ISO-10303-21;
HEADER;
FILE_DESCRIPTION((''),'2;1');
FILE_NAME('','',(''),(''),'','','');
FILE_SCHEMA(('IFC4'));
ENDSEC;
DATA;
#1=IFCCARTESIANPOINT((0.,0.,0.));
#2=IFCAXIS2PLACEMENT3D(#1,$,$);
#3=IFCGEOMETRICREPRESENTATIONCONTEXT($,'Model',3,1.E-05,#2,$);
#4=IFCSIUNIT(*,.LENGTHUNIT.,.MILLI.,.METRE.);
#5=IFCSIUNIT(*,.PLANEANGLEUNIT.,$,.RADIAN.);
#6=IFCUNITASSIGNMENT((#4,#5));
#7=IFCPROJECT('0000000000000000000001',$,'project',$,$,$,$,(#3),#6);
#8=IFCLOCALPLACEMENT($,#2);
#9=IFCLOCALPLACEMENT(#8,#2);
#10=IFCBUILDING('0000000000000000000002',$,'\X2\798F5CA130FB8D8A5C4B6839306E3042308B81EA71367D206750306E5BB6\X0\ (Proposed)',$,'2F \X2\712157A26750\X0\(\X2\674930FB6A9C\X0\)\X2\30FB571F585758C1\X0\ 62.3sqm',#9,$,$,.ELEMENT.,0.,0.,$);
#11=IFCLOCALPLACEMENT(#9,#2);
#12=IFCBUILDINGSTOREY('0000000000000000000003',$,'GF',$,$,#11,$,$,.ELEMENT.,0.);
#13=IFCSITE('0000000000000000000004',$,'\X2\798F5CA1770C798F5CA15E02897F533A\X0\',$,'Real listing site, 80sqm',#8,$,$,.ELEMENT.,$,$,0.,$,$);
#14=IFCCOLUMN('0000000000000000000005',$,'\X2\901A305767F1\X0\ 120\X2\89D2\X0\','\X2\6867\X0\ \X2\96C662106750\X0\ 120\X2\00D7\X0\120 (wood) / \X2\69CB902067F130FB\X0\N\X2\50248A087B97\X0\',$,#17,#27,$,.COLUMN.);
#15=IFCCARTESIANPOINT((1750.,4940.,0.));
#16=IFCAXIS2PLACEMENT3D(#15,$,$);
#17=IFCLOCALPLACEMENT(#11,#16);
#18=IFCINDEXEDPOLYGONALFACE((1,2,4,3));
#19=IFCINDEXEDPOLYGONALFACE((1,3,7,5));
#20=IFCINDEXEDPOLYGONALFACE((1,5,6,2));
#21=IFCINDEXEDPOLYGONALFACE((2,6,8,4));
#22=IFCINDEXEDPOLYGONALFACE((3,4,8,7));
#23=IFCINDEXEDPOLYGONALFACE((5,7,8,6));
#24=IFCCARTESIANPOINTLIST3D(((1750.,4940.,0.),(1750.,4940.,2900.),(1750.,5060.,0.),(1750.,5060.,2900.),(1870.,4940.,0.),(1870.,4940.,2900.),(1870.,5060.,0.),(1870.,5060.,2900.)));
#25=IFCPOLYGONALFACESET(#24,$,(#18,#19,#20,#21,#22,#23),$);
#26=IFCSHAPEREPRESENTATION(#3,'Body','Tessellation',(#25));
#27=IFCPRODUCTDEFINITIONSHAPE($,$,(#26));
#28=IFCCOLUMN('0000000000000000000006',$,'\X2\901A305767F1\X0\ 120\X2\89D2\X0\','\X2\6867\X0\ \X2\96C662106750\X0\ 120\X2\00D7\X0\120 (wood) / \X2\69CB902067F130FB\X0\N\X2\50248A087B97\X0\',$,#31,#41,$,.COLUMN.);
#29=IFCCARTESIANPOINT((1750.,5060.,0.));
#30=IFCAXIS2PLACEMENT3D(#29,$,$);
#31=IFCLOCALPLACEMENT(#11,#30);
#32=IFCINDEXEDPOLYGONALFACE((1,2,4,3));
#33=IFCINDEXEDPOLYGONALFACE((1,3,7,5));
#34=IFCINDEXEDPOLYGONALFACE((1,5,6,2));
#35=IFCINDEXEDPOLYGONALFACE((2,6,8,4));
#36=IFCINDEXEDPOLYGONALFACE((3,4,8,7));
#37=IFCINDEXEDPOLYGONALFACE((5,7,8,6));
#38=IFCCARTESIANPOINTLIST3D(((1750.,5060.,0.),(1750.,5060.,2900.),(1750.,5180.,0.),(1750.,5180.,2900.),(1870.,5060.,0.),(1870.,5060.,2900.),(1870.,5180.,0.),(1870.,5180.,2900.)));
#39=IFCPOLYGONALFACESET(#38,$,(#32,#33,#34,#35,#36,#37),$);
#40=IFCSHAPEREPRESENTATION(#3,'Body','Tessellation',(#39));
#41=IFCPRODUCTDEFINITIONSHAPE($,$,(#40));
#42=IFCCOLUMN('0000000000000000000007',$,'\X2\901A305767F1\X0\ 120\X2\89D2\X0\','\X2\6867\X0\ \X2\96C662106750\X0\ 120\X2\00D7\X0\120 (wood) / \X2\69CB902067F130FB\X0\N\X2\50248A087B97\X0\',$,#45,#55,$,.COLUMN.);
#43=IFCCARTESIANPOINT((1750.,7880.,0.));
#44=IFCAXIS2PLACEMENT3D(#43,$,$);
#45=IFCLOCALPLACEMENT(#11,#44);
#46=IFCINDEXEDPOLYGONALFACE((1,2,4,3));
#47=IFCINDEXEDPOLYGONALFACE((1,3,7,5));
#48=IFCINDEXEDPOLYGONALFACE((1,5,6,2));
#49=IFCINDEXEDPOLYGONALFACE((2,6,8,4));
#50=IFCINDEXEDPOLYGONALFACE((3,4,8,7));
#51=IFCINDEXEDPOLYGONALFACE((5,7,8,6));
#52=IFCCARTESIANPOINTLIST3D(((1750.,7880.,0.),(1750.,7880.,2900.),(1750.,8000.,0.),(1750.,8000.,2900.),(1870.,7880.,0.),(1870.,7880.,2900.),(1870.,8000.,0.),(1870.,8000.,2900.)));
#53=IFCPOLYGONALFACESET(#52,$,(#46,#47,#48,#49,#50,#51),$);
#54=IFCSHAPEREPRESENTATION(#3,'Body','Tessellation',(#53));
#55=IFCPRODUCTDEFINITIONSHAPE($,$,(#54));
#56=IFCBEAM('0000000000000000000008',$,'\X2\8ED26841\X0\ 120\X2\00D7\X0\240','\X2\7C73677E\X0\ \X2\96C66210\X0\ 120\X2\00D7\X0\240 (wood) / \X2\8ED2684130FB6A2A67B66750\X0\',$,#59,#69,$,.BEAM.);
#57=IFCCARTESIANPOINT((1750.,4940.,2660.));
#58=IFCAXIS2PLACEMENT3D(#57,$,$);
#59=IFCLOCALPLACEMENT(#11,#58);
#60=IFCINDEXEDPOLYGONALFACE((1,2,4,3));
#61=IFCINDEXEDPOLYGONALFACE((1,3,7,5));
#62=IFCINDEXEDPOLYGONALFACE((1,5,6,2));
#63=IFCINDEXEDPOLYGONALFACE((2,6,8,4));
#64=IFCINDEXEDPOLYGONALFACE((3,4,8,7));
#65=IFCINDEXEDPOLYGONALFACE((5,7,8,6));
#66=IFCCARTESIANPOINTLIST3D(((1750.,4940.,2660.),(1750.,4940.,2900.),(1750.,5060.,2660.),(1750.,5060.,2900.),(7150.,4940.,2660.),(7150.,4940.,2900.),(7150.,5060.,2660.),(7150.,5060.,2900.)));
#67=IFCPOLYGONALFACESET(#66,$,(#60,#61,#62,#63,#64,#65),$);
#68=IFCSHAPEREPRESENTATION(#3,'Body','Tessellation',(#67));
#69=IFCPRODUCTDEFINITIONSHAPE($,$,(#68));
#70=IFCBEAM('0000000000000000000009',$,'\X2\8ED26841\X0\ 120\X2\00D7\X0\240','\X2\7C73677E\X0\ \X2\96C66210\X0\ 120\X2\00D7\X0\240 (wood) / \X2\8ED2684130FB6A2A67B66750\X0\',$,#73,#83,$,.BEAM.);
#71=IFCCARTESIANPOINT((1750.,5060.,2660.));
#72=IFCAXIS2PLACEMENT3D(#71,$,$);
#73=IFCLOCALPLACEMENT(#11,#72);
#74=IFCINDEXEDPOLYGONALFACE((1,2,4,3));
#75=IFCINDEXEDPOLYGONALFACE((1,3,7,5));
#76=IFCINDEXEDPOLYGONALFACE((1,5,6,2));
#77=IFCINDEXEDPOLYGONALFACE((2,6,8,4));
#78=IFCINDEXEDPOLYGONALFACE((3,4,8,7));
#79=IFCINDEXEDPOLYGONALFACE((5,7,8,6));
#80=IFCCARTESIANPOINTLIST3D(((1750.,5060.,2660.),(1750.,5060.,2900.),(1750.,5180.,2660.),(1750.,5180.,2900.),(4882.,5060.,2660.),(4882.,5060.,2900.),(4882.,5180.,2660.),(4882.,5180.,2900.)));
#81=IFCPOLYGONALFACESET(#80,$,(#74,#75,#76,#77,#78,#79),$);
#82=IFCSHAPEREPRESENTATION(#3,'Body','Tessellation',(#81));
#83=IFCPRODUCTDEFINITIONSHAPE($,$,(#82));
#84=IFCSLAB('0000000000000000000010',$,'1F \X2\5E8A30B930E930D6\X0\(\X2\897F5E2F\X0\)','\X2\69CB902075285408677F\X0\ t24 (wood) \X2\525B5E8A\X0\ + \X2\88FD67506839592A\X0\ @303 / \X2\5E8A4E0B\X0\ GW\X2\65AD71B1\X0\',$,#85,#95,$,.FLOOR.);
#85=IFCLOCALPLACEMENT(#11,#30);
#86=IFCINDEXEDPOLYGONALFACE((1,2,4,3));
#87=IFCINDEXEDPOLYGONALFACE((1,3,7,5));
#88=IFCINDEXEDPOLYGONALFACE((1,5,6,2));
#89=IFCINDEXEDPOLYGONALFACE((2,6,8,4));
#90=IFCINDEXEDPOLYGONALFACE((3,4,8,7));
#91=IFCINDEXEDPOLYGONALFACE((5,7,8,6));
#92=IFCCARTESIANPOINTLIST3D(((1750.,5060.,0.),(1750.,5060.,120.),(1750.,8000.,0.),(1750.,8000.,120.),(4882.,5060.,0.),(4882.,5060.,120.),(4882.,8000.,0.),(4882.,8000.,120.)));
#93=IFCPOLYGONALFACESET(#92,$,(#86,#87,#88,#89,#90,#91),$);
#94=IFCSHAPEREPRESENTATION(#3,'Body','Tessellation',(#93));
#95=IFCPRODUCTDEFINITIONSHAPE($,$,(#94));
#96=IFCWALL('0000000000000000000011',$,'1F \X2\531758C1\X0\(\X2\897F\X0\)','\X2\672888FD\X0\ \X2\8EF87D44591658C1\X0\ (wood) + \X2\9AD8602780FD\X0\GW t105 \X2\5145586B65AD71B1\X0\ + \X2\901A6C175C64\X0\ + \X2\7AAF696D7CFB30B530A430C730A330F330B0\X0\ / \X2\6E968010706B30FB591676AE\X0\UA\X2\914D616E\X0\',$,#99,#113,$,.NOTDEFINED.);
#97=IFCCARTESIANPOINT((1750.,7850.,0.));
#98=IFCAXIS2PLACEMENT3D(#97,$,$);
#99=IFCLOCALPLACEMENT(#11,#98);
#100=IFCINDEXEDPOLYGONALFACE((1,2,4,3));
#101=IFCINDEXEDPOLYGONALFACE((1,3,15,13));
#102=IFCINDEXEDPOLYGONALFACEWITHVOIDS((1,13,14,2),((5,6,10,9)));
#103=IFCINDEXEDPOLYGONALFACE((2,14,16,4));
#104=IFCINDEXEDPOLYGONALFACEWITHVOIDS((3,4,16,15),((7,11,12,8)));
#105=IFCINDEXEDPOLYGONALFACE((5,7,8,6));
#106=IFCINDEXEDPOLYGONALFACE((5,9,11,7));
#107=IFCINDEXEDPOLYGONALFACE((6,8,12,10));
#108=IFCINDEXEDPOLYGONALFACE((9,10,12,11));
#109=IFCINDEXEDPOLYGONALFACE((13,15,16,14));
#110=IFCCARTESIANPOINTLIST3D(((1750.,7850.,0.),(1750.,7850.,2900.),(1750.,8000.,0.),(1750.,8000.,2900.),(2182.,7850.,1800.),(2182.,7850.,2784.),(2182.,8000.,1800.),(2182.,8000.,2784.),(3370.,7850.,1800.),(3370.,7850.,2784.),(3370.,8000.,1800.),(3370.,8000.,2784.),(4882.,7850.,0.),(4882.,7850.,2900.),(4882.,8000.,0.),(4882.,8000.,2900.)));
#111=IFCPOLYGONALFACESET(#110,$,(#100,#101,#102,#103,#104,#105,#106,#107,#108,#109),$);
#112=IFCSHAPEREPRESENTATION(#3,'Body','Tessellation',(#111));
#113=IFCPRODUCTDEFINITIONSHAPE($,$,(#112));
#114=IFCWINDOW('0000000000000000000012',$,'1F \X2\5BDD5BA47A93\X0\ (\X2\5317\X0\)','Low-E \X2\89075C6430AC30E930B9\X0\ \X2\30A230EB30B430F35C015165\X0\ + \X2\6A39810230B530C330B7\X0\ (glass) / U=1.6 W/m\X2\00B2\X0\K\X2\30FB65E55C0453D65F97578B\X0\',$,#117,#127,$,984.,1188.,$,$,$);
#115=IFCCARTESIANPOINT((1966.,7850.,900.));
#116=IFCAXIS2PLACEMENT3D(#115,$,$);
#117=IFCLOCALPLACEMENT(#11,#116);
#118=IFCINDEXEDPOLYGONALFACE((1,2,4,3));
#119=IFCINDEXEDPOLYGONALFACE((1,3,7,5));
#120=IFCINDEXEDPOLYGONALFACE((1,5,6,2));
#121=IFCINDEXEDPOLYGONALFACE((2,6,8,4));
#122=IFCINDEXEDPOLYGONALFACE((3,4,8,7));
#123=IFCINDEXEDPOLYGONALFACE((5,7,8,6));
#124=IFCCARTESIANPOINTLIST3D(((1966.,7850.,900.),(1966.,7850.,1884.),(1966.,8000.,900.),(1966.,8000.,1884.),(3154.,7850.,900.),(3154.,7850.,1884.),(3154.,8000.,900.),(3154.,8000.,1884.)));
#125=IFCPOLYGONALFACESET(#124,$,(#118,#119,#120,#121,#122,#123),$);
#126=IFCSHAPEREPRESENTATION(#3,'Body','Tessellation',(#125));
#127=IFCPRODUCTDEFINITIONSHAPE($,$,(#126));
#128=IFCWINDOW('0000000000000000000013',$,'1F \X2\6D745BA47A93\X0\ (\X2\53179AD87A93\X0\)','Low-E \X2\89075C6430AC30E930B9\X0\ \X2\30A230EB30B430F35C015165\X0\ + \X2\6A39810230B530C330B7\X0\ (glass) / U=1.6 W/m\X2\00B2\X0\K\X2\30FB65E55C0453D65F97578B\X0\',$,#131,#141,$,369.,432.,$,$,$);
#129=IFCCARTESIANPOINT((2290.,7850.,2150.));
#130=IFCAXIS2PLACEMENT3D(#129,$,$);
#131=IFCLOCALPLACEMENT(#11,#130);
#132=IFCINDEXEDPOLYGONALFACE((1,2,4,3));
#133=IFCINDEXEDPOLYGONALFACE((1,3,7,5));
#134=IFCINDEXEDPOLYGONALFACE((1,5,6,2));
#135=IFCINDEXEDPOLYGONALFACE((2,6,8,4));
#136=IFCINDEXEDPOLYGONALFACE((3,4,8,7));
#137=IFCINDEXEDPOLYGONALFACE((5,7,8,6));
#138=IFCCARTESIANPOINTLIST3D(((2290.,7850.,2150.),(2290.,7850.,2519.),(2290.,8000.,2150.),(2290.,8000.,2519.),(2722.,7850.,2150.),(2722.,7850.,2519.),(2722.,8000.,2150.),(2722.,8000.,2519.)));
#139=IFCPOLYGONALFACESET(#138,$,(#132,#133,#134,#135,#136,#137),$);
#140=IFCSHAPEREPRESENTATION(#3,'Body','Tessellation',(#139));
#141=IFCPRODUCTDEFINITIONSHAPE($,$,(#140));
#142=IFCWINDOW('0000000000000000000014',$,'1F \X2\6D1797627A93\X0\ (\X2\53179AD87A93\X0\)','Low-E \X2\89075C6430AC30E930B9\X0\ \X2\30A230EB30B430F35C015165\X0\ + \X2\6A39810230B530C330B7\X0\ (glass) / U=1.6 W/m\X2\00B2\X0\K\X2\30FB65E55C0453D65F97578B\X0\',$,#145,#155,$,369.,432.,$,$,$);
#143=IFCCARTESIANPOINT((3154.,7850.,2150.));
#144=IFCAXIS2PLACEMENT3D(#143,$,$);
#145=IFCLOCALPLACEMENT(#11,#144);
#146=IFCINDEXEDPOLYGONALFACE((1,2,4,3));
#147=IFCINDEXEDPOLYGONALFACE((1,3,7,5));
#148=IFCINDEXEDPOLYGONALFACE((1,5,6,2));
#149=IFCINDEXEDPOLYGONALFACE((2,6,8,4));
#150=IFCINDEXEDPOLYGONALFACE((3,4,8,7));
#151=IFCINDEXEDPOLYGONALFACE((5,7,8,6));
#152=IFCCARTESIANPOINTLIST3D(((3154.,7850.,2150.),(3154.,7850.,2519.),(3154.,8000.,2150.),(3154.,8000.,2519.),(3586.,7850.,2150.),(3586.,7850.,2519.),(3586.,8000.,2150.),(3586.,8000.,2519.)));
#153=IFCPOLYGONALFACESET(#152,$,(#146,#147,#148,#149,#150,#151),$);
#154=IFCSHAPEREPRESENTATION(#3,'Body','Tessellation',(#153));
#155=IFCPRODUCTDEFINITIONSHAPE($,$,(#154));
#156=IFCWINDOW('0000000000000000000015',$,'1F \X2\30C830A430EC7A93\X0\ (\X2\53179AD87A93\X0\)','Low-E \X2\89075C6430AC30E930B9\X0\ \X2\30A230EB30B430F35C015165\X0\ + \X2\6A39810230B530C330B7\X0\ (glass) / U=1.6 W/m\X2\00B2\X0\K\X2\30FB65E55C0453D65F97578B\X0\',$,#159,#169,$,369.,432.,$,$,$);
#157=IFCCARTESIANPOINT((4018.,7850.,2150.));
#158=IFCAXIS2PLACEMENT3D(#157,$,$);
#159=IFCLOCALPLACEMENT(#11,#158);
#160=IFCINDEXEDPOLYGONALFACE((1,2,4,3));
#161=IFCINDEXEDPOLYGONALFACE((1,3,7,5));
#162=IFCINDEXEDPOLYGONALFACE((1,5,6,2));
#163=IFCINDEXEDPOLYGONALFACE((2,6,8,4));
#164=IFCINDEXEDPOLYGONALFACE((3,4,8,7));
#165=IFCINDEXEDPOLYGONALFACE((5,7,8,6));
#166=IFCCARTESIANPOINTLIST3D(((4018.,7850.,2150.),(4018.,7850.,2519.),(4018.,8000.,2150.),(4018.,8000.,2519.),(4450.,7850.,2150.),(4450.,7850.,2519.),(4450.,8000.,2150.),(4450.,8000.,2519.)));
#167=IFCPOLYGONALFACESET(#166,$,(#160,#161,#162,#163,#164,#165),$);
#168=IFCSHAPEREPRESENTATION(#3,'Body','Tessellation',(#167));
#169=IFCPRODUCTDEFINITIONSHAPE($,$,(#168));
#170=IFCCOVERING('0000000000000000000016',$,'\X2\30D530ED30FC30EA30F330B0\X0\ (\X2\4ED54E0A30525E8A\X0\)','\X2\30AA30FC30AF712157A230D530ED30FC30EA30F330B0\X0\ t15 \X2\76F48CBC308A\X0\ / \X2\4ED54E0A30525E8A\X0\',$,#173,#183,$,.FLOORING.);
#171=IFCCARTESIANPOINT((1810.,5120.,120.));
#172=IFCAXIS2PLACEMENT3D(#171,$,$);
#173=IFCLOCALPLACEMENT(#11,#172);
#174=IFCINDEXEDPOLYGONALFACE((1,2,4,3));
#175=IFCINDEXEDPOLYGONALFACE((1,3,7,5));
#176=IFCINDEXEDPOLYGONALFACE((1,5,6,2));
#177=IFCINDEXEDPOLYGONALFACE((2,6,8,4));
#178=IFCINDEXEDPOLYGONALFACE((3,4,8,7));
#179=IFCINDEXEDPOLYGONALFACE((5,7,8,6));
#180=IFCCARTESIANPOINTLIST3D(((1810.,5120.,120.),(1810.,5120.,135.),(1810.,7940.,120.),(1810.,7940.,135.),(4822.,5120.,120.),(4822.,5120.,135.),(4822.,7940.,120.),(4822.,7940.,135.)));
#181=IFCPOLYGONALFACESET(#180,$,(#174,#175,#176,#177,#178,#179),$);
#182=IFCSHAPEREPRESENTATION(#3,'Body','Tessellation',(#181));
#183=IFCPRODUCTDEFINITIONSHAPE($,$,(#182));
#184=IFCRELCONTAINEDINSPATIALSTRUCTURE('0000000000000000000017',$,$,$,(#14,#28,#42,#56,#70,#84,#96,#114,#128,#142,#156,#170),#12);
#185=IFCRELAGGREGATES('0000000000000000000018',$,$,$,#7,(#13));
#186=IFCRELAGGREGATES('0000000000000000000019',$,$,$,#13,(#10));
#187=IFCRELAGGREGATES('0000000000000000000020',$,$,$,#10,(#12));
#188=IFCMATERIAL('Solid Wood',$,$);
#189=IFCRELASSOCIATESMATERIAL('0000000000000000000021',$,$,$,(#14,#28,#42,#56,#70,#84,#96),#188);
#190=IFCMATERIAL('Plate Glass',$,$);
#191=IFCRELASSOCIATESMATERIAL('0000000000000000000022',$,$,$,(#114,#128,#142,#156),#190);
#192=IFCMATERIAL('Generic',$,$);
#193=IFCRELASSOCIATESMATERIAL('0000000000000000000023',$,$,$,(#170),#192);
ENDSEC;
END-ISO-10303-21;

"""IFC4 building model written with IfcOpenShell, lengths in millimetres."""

from ifc_helpers import new_model, si_unit, frame, frame_2d, origin, place, context, project, spatial, rectangle, extrude, material, element, fill, save


model = new_model("IFC4")

# Units and contexts
model_context = context("Model", 3, precision=1e-05, world=origin())
ifc_project = project(units=[si_unit("LENGTHUNIT", "METRE", prefix="MILLI"), si_unit("PLANEANGLEUNIT", "RADIAN")], contexts=[model_context])

# Site, building, storey
site_placement = place(None, origin())
site = spatial("IfcSite", under=ifc_project, at=site_placement, Name="福岡県福岡市西区", ObjectType="Real listing site, 80sqm", CompositionType="ELEMENT", RefElevation=0.0)
building_placement = place(site_placement, origin())
building = spatial("IfcBuilding", under=site, at=building_placement, Name="福岡・越屋根のある自然素材の家 (Proposed)", ObjectType="2F 無垢材(杉・檜)・土塗壁 62.3sqm", CompositionType="ELEMENT", ElevationOfRefHeight=0.0, ElevationOfTerrain=0.0)
storey_placement = place(building_placement, origin())
storey = spatial("IfcBuildingStorey", under=building, at=storey_placement, Name="GF", CompositionType="ELEMENT", Elevation=0.0)

# Columns
ifc_material_1 = material(Name="Solid Wood")
column_1_placement = place(storey_placement, frame((1750.0, 4940.0, 0.0)))
element("IfcColumn", 1, at=column_1_placement, inside=storey, material=ifc_material_1, Name="通し柱 120角", Description="桧 集成材 120×120 (wood) / 構造柱・N値計算", PredefinedType="COLUMN", context=model_context, shape_type="SweptSolid", body=[
    extrude(rectangle(XDim=120.0, YDim=120.0, at=frame_2d((60.0, 60.0))), frame((1750.0, 4940.0, 0.0)), (0.0, 0.0, 1.0), 2900.0),
])
column_2_placement = place(storey_placement, frame((1750.0, 5060.0, 0.0)))
element("IfcColumn", 2, at=column_2_placement, inside=storey, material=ifc_material_1, Name="通し柱 120角", Description="桧 集成材 120×120 (wood) / 構造柱・N値計算", PredefinedType="COLUMN", context=model_context, shape_type="SweptSolid", body=[
    extrude(rectangle(XDim=120.0, YDim=120.0, at=frame_2d((60.0, 60.0))), frame((1750.0, 5060.0, 0.0)), (0.0, 0.0, 1.0), 2900.0),
])
column_3_placement = place(storey_placement, frame((1750.0, 7880.0, 0.0)))
element("IfcColumn", 3, at=column_3_placement, inside=storey, material=ifc_material_1, Name="通し柱 120角", Description="桧 集成材 120×120 (wood) / 構造柱・N値計算", PredefinedType="COLUMN", context=model_context, shape_type="SweptSolid", body=[
    extrude(rectangle(XDim=120.0, YDim=120.0, at=frame_2d((60.0, 60.0))), frame((1750.0, 7880.0, 0.0)), (0.0, 0.0, 1.0), 2900.0),
])

# Beams
beam_1_placement = place(storey_placement, frame((1750.0, 4940.0, 2660.0)))
element("IfcBeam", 4, at=beam_1_placement, inside=storey, material=ifc_material_1, Name="軒桁 120×240", Description="米松 集成 120×240 (wood) / 軒桁・横架材", PredefinedType="BEAM", context=model_context, shape_type="SweptSolid", body=[
    extrude(rectangle(XDim=5400.0, YDim=120.0, at=frame_2d((2700.0, 60.0))), frame((1750.0, 4940.0, 2660.0)), (0.0, 0.0, 1.0), 240.0),
])
beam_2_placement = place(storey_placement, frame((1750.0, 5060.0, 2660.0)))
element("IfcBeam", 5, at=beam_2_placement, inside=storey, material=ifc_material_1, Name="軒桁 120×240", Description="米松 集成 120×240 (wood) / 軒桁・横架材", PredefinedType="BEAM", context=model_context, shape_type="SweptSolid", body=[
    extrude(rectangle(XDim=3132.0, YDim=120.0, at=frame_2d((1566.0, 60.0))), frame((1750.0, 5060.0, 2660.0)), (0.0, 0.0, 1.0), 240.0),
])

# Slab
slab_placement = place(storey_placement, frame((1750.0, 5060.0, 0.0)))
element("IfcSlab", 6, at=slab_placement, inside=storey, material=ifc_material_1, Name="1F 床スラブ(西帯)", Description="構造用合板 t24 (wood) 剛床 + 製材根太 @303 / 床下 GW断熱", PredefinedType="FLOOR", context=model_context, shape_type="SweptSolid", body=[
    extrude(rectangle(XDim=3132.0, YDim=2940.0, at=frame_2d((1566.0, 1470.0))), frame((1750.0, 5060.0, 0.0)), (0.0, 0.0, 1.0), 120.0),
])

# Wall, openings, windows
wall_1_placement = place(storey_placement, frame((1750.0, 7850.0, 0.0)))
wall_1 = element("IfcWall", 7, at=wall_1_placement, inside=storey, material=ifc_material_1, Name="1F 北壁(西)", Description="木製 軸組外壁 (wood) + 高性能GW t105 充填断熱 + 通気層 + 窯業系サイディング / 準耐火・外皮UA配慮", PredefinedType="NOTDEFINED", context=model_context, shape_type="SweptSolid", body=[
    extrude(rectangle(XDim=3132.0, YDim=150.0, at=frame_2d((1566.0, 75.0))), frame((1750.0, 7850.0, 0.0)), (0.0, 0.0, 1.0), 2900.0),
])
opening_1_placement = place(storey_placement, frame((1966.0, 7850.0, 900.0)))
opening_1 = element("IfcOpeningElement", 8, at=opening_1_placement, cuts=wall_1, PredefinedType="NOTDEFINED", context=model_context, shape_type="SweptSolid", body=[
    extrude(rectangle(XDim=1188.0, YDim=150.0, at=frame_2d((594.0, 75.0))), frame((1966.0, 7850.0, 900.0)), (0.0, 0.0, 1.0), 984.0),
])
opening_2_placement = place(storey_placement, frame((2290.0, 7850.0, 2150.0)))
opening_2 = element("IfcOpeningElement", 9, at=opening_2_placement, cuts=wall_1, PredefinedType="NOTDEFINED", context=model_context, shape_type="SweptSolid", body=[
    extrude(rectangle(XDim=432.0, YDim=150.0, at=frame_2d((216.0, 75.0))), frame((2290.0, 7850.0, 2150.0)), (0.0, 0.0, 1.0), 369.0),
])
opening_3_placement = place(storey_placement, frame((3154.0, 7850.0, 2150.0)))
opening_3 = element("IfcOpeningElement", 10, at=opening_3_placement, cuts=wall_1, PredefinedType="NOTDEFINED", context=model_context, shape_type="SweptSolid", body=[
    extrude(rectangle(XDim=432.0, YDim=150.0, at=frame_2d((216.0, 75.0))), frame((3154.0, 7850.0, 2150.0)), (0.0, 0.0, 1.0), 369.0),
])
opening_4_placement = place(storey_placement, frame((4018.0, 7850.0, 2150.0)))
opening_4 = element("IfcOpeningElement", 11, at=opening_4_placement, cuts=wall_1, PredefinedType="NOTDEFINED", context=model_context, shape_type="SweptSolid", body=[
    extrude(rectangle(XDim=432.0, YDim=150.0, at=frame_2d((216.0, 75.0))), frame((4018.0, 7850.0, 2150.0)), (0.0, 0.0, 1.0), 369.0),
])
ifc_material_2 = material(Name="Plate Glass")
window_1_placement = place(storey_placement, frame((1966.0, 7850.0, 900.0)))
window_1 = element("IfcWindow", 12, at=window_1_placement, inside=storey, material=ifc_material_2, Name="1F 寝室窓 (北)", Description="Low-E 複層ガラス アルゴン封入 + 樹脂サッシ (glass) / U=1.6 W/m²K・日射取得型", OverallHeight=984.0, OverallWidth=1188.0, context=model_context, shape_type="SweptSolid", body=[
    extrude(rectangle(XDim=1188.0, YDim=150.0, at=frame_2d((594.0, 75.0))), frame((1966.0, 7850.0, 900.0)), (0.0, 0.0, 1.0), 984.0),
])
fill(opening_1, window_1)
window_2_placement = place(storey_placement, frame((2290.0, 7850.0, 2150.0)))
window_2 = element("IfcWindow", 13, at=window_2_placement, inside=storey, material=ifc_material_2, Name="1F 浴室窓 (北高窓)", Description="Low-E 複層ガラス アルゴン封入 + 樹脂サッシ (glass) / U=1.6 W/m²K・日射取得型", OverallHeight=369.0, OverallWidth=432.0, context=model_context, shape_type="SweptSolid", body=[
    extrude(rectangle(XDim=432.0, YDim=150.0, at=frame_2d((216.0, 75.0))), frame((2290.0, 7850.0, 2150.0)), (0.0, 0.0, 1.0), 369.0),
])
fill(opening_2, window_2)
window_3_placement = place(storey_placement, frame((3154.0, 7850.0, 2150.0)))
window_3 = element("IfcWindow", 14, at=window_3_placement, inside=storey, material=ifc_material_2, Name="1F 洗面窓 (北高窓)", Description="Low-E 複層ガラス アルゴン封入 + 樹脂サッシ (glass) / U=1.6 W/m²K・日射取得型", OverallHeight=369.0, OverallWidth=432.0, context=model_context, shape_type="SweptSolid", body=[
    extrude(rectangle(XDim=432.0, YDim=150.0, at=frame_2d((216.0, 75.0))), frame((3154.0, 7850.0, 2150.0)), (0.0, 0.0, 1.0), 369.0),
])
fill(opening_3, window_3)
window_4_placement = place(storey_placement, frame((4018.0, 7850.0, 2150.0)))
window_4 = element("IfcWindow", 15, at=window_4_placement, inside=storey, material=ifc_material_2, Name="1F トイレ窓 (北高窓)", Description="Low-E 複層ガラス アルゴン封入 + 樹脂サッシ (glass) / U=1.6 W/m²K・日射取得型", OverallHeight=369.0, OverallWidth=432.0, context=model_context, shape_type="SweptSolid", body=[
    extrude(rectangle(XDim=432.0, YDim=150.0, at=frame_2d((216.0, 75.0))), frame((4018.0, 7850.0, 2150.0)), (0.0, 0.0, 1.0), 369.0),
])
fill(opening_4, window_4)

# Covering
ifc_material_3 = material(Name="Generic")
covering_placement = place(storey_placement, frame((1810.0, 5120.0, 120.0)))
element("IfcCovering", 16, at=covering_placement, inside=storey, material=ifc_material_3, Name="フローリング (仕上げ床)", Description="オーク無垢フローリング t15 直貼り / 仕上げ床", PredefinedType="FLOORING", context=model_context, shape_type="SweptSolid", body=[
    extrude(rectangle(XDim=3012.0, YDim=2820.0, at=frame_2d((1506.0, 1410.0))), frame((1810.0, 5120.0, 120.0)), (0.0, 0.0, 1.0), 15.0),
])

save(model, "model.ifc")
